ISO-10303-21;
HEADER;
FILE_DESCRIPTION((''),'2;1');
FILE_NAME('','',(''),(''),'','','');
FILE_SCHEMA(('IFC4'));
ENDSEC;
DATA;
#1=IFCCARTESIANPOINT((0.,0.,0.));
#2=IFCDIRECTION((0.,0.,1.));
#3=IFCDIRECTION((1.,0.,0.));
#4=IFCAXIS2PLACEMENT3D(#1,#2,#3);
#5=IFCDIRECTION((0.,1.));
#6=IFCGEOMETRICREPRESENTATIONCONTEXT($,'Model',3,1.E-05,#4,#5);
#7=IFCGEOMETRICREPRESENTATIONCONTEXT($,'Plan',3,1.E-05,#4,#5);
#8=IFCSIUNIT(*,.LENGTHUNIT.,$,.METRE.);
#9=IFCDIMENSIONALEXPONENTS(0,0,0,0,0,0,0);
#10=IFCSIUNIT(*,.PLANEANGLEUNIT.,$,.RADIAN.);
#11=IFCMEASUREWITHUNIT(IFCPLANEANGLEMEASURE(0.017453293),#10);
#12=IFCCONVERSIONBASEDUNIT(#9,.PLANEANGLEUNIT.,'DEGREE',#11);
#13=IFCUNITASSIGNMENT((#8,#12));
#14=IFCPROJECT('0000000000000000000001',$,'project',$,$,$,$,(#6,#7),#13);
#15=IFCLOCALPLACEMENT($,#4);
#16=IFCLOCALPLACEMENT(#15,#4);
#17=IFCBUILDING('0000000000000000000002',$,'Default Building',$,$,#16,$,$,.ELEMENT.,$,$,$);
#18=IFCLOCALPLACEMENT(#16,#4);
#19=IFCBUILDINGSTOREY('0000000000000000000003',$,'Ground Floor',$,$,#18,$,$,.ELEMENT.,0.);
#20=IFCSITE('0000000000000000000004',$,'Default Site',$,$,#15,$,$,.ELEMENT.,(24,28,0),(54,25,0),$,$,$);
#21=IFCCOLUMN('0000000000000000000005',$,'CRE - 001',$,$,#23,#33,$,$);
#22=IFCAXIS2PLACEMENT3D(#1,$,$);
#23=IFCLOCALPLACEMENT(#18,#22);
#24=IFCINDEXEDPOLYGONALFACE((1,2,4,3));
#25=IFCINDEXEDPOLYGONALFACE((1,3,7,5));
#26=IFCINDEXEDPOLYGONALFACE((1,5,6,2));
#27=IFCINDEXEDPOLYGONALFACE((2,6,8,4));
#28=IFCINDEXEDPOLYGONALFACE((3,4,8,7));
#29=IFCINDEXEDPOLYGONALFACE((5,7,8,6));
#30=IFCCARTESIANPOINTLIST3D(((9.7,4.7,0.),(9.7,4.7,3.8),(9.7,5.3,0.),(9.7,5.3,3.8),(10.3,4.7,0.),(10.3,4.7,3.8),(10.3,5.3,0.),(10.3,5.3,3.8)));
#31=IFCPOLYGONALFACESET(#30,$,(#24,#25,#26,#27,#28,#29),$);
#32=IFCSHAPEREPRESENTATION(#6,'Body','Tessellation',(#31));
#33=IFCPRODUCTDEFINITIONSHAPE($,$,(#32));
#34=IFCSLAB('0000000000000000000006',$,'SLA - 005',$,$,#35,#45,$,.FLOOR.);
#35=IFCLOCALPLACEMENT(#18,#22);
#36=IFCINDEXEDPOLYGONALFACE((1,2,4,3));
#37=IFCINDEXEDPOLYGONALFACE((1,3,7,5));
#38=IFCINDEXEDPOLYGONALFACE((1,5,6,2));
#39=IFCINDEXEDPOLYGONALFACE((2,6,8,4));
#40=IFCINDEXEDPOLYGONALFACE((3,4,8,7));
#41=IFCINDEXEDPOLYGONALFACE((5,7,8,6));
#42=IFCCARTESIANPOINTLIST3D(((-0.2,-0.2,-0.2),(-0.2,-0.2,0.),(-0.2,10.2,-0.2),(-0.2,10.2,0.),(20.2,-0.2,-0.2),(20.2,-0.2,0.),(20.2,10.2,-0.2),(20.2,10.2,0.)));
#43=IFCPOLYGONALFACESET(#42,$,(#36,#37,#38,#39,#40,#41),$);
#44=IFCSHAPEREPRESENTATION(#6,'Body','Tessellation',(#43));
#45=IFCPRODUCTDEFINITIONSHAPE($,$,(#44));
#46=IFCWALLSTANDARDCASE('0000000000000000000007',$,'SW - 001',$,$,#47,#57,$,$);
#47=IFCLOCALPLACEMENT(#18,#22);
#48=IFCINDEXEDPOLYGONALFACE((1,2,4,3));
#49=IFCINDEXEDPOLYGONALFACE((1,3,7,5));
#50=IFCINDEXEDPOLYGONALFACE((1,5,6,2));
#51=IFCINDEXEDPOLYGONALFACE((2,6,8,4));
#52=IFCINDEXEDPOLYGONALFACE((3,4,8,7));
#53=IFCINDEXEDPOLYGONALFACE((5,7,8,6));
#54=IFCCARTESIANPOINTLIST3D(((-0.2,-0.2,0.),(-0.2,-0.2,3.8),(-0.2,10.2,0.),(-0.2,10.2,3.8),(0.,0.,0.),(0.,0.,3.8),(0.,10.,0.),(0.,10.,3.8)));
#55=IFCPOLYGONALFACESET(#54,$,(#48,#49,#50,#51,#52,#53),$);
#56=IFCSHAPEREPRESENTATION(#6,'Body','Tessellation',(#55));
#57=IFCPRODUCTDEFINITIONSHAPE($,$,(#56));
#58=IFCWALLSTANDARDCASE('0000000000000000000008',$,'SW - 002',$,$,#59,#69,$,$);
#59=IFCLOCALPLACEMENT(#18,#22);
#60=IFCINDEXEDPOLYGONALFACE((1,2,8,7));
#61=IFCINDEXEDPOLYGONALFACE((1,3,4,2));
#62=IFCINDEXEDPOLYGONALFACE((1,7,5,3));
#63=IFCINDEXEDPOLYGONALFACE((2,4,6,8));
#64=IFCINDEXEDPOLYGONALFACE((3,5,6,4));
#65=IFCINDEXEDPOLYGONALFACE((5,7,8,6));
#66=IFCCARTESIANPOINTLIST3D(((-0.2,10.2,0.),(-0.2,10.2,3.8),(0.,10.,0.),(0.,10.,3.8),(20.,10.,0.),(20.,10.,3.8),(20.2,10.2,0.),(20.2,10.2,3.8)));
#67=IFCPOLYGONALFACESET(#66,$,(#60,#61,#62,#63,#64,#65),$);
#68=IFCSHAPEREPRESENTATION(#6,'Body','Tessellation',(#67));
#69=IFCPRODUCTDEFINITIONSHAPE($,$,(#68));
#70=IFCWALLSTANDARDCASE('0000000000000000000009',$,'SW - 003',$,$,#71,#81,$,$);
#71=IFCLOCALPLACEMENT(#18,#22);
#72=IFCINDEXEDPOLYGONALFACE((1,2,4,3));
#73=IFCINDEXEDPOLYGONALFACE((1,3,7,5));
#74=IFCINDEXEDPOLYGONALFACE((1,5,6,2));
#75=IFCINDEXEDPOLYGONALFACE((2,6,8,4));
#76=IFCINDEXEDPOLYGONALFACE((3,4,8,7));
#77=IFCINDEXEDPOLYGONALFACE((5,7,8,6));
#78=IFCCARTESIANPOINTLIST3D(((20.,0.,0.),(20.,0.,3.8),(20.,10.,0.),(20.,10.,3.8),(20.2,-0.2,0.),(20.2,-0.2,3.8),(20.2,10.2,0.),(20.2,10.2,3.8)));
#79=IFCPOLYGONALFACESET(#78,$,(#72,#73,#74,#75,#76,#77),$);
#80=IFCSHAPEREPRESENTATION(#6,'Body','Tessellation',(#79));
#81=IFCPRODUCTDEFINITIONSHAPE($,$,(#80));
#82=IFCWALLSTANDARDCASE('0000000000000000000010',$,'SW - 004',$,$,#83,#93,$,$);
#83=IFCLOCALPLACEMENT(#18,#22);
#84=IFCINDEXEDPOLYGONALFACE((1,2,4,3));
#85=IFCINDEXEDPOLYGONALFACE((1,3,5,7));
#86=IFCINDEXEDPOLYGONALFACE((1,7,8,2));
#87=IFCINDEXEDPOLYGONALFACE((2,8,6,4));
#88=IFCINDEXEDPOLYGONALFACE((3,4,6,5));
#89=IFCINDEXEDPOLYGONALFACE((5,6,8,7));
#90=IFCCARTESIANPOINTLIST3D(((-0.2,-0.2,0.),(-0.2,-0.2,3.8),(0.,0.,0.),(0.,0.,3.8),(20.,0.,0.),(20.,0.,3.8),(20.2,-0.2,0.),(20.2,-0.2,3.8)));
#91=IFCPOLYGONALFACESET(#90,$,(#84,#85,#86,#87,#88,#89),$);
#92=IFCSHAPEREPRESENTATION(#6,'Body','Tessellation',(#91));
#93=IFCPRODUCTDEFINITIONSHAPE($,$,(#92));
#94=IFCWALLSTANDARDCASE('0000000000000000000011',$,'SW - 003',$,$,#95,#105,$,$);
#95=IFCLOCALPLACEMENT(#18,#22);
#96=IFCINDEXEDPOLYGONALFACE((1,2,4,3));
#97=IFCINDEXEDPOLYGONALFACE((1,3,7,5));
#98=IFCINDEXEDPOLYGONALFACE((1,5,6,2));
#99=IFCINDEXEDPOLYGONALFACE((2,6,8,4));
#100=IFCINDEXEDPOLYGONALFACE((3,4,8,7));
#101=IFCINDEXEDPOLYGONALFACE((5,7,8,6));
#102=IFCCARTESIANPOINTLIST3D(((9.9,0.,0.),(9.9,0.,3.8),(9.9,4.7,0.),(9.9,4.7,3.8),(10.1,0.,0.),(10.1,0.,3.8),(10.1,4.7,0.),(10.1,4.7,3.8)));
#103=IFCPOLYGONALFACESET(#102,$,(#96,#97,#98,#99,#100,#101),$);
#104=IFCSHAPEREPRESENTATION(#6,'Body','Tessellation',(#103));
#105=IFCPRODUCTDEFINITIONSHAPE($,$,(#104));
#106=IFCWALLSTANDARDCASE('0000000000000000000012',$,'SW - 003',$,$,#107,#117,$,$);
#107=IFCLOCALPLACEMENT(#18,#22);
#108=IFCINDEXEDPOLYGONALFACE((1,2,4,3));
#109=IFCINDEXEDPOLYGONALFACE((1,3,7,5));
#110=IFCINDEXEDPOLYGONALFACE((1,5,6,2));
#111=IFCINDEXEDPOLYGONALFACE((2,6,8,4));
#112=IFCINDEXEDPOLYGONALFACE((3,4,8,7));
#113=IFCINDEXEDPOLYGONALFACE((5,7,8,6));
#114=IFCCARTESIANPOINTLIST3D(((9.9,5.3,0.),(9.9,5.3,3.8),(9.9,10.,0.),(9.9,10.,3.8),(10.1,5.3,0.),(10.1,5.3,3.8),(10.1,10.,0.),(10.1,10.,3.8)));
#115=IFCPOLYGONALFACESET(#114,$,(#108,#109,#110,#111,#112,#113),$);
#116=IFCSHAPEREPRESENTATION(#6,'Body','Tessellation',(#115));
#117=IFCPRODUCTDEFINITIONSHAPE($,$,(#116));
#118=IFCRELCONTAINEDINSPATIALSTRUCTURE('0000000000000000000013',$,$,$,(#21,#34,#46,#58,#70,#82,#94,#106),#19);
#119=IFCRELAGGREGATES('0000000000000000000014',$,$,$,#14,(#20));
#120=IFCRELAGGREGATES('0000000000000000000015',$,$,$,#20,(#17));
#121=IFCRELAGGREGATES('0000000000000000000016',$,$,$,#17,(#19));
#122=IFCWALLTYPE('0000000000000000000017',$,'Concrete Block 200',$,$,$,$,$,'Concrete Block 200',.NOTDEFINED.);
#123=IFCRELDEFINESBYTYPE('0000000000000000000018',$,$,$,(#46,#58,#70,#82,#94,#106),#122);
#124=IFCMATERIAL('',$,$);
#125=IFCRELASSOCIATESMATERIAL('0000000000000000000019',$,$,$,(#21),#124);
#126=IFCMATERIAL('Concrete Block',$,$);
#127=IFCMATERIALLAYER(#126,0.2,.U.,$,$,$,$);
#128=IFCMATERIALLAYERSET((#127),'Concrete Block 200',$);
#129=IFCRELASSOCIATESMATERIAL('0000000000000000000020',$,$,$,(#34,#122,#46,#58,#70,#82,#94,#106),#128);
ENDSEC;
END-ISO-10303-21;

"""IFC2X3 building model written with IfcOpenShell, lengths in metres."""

from ifc_helpers import new_model, entity, si_unit, converted_unit, direction, frame, origin_with_axes, origin_2d_with_axis, place, context, project, spatial, polyline, rectangle, outline, extrude, material, layer, layer_set, layer_usage, type_object, element, save


model = new_model("IFC2X3")

# Units and contexts
model_context = context("Model", 3, precision=1e-05, world=origin_with_axes(), true_north=direction((0.0, 1.0)))
plan_context = context("Plan", 3, precision=1e-05, world=origin_with_axes(), true_north=direction((0.0, 1.0)))
ifc_project = project(units=[si_unit("LENGTHUNIT", "METRE"), converted_unit("PLANEANGLEUNIT", "DEGREE", entity("IfcPlaneAngleMeasure", 0.017453293), si_unit("PLANEANGLEUNIT", "RADIAN"), dimensions=[0, 0, 0, 0, 0, 0, 0])], contexts=[model_context, plan_context])

# Site, building, storey
site_placement = place(None, origin_with_axes())
site = spatial("IfcSite", under=ifc_project, at=site_placement, Name="Default Site", CompositionType="ELEMENT", RefLatitude=(24, 28, 0), RefLongitude=(54, 25, 0))
building_placement = place(site_placement, origin_with_axes())
building = spatial("IfcBuilding", under=site, at=building_placement, Name="Default Building", CompositionType="ELEMENT")
storey_placement = place(building_placement, origin_with_axes())
storey = spatial("IfcBuildingStorey", under=building, at=storey_placement, Name="Ground Floor", CompositionType="ELEMENT", Elevation=0.0)

# Column
ifc_material_1 = material(Name="")
column_placement = place(storey_placement, frame((10.0, 5.0, 0.0), z_axis=(0.0, 0.0, 1.0), x_axis=(1.0, 0.0, 0.0)))
element("IfcColumn", 1, at=column_placement, inside=storey, material=ifc_material_1, Name="CRE - 001", context=model_context, shape_type="SweptSolid", body=[
    extrude(rectangle(XDim=0.6, YDim=0.6, at=origin_2d_with_axis()), origin_with_axes(), (0.0, 0.0, 1.0), 3.8),
])

# Slab
ifc_material_2 = material(Name="Concrete Block")
ifc_layer = layer(ifc_material_2, 0.2, ventilated="UNKNOWN")
ifc_layer_set = layer_set([ifc_layer], Name="Concrete Block 200")
ifc_layer_usage_1 = layer_usage(ifc_layer_set, "AXIS3", "NEGATIVE", 0.2)
slab_placement = place(storey_placement, frame((-0.2, 10.2, -0.2), z_axis=(0.0, 0.0, 1.0), x_axis=(1.0, 0.0, 0.0)))
element("IfcSlab", 2, at=slab_placement, inside=storey, material=ifc_layer_usage_1, Name="SLA - 005", PredefinedType="FLOOR", context=model_context, shape_type="SweptSolid", body=[
    extrude(outline(polyline([(0.0, 0.0), (20.4, 0.0), (20.4, -10.4), (0.0, -10.4), (0.0, 0.0)])), origin_with_axes(), (0.0, 0.0, 1.0), 0.2),
])

# Walls
ifc_layer_usage_2 = layer_usage(ifc_layer_set, "AXIS2", "POSITIVE", 0.0)
wall_type = type_object("IfcWallType", Name="Concrete Block 200", ElementType="Concrete Block 200", PredefinedType="NOTDEFINED", material=ifc_layer_set)
wall_1_placement = place(storey_placement, frame((0.0, 0.0, 0.0), z_axis=(0.0, 0.0, 1.0), x_axis=(0.0, 1.0, 0.0)))
element("IfcWallStandardCase", 3, at=wall_1_placement, inside=storey, type_object=wall_type, material=ifc_layer_usage_2, Name="SW - 001", context=model_context, shape_type="SweptSolid", body=[
    extrude(outline(polyline([(0.0, 0.0), (10.0, 0.0), (10.2, 0.2), (-0.2, 0.2), (0.0, 0.0)])), origin_with_axes(), (0.0, 0.0, 1.0), 3.8),
])
ifc_layer_usage_3 = layer_usage(ifc_layer_set, "AXIS2", "POSITIVE", 0.0)
wall_2_placement = place(storey_placement, frame((0.0, 10.0, 0.0), z_axis=(0.0, 0.0, 1.0), x_axis=(1.0, 0.0, 0.0)))
element("IfcWallStandardCase", 4, at=wall_2_placement, inside=storey, type_object=wall_type, material=ifc_layer_usage_3, Name="SW - 002", context=model_context, shape_type="SweptSolid", body=[
    extrude(outline(polyline([(0.0, 0.0), (20.0, 0.0), (20.2, 0.2), (-0.2, 0.2), (0.0, 0.0)])), origin_with_axes(), (0.0, 0.0, 1.0), 3.8),
])
ifc_layer_usage_4 = layer_usage(ifc_layer_set, "AXIS2", "POSITIVE", 0.0)
wall_3_placement = place(storey_placement, frame((20.0, 10.0, 0.0), z_axis=(0.0, 0.0, 1.0), x_axis=(0.0, -1.0, 0.0)))
element("IfcWallStandardCase", 5, at=wall_3_placement, inside=storey, type_object=wall_type, material=ifc_layer_usage_4, Name="SW - 003", context=model_context, shape_type="SweptSolid", body=[
    extrude(outline(polyline([(0.0, 0.0), (10.0, 0.0), (10.2, 0.2), (-0.2, 0.2), (0.0, 0.0)])), origin_with_axes(), (0.0, 0.0, 1.0), 3.8),
])
ifc_layer_usage_5 = layer_usage(ifc_layer_set, "AXIS2", "POSITIVE", 0.0)
wall_4_placement = place(storey_placement, frame((20.0, 0.0, 0.0), z_axis=(0.0, 0.0, 1.0), x_axis=(-1.0, 0.0, 0.0)))
element("IfcWallStandardCase", 6, at=wall_4_placement, inside=storey, type_object=wall_type, material=ifc_layer_usage_5, Name="SW - 004", context=model_context, shape_type="SweptSolid", body=[
    extrude(outline(polyline([(0.0, 0.0), (20.0, 0.0), (20.2, 0.2), (-0.2, 0.2), (0.0, 0.0)])), origin_with_axes(), (0.0, 0.0, 1.0), 3.8),
])
ifc_layer_usage_6 = layer_usage(ifc_layer_set, "AXIS2", "NEGATIVE", 0.0)
wall_5_placement = place(storey_placement, frame((10.1, 4.7, 0.0), z_axis=(0.0, 0.0, 1.0), x_axis=(0.0, -1.0, 0.0)))
element("IfcWallStandardCase", 7, at=wall_5_placement, inside=storey, type_object=wall_type, material=ifc_layer_usage_6, Name="SW - 003", context=model_context, shape_type="SweptSolid", body=[
    extrude(outline(polyline([(0.0, -0.2), (4.7, -0.2), (4.7, 0.0), (0.0, 0.0), (0.0, -0.2)])), origin_with_axes(), (0.0, 0.0, 1.0), 3.8),
])
ifc_layer_usage_7 = layer_usage(ifc_layer_set, "AXIS2", "NEGATIVE", 0.0)
wall_6_placement = place(storey_placement, frame((10.1, 10.0, 0.0), z_axis=(0.0, 0.0, 1.0), x_axis=(0.0, -1.0, 0.0)))
element("IfcWallStandardCase", 8, at=wall_6_placement, inside=storey, type_object=wall_type, material=ifc_layer_usage_7, Name="SW - 003", context=model_context, shape_type="SweptSolid", body=[
    extrude(outline(polyline([(0.0, -0.2), (4.7, -0.2), (4.7, 0.0), (0.0, 0.0), (0.0, -0.2)])), origin_with_axes(), (0.0, 0.0, 1.0), 3.8),
])

save(model, "model.ifc")
